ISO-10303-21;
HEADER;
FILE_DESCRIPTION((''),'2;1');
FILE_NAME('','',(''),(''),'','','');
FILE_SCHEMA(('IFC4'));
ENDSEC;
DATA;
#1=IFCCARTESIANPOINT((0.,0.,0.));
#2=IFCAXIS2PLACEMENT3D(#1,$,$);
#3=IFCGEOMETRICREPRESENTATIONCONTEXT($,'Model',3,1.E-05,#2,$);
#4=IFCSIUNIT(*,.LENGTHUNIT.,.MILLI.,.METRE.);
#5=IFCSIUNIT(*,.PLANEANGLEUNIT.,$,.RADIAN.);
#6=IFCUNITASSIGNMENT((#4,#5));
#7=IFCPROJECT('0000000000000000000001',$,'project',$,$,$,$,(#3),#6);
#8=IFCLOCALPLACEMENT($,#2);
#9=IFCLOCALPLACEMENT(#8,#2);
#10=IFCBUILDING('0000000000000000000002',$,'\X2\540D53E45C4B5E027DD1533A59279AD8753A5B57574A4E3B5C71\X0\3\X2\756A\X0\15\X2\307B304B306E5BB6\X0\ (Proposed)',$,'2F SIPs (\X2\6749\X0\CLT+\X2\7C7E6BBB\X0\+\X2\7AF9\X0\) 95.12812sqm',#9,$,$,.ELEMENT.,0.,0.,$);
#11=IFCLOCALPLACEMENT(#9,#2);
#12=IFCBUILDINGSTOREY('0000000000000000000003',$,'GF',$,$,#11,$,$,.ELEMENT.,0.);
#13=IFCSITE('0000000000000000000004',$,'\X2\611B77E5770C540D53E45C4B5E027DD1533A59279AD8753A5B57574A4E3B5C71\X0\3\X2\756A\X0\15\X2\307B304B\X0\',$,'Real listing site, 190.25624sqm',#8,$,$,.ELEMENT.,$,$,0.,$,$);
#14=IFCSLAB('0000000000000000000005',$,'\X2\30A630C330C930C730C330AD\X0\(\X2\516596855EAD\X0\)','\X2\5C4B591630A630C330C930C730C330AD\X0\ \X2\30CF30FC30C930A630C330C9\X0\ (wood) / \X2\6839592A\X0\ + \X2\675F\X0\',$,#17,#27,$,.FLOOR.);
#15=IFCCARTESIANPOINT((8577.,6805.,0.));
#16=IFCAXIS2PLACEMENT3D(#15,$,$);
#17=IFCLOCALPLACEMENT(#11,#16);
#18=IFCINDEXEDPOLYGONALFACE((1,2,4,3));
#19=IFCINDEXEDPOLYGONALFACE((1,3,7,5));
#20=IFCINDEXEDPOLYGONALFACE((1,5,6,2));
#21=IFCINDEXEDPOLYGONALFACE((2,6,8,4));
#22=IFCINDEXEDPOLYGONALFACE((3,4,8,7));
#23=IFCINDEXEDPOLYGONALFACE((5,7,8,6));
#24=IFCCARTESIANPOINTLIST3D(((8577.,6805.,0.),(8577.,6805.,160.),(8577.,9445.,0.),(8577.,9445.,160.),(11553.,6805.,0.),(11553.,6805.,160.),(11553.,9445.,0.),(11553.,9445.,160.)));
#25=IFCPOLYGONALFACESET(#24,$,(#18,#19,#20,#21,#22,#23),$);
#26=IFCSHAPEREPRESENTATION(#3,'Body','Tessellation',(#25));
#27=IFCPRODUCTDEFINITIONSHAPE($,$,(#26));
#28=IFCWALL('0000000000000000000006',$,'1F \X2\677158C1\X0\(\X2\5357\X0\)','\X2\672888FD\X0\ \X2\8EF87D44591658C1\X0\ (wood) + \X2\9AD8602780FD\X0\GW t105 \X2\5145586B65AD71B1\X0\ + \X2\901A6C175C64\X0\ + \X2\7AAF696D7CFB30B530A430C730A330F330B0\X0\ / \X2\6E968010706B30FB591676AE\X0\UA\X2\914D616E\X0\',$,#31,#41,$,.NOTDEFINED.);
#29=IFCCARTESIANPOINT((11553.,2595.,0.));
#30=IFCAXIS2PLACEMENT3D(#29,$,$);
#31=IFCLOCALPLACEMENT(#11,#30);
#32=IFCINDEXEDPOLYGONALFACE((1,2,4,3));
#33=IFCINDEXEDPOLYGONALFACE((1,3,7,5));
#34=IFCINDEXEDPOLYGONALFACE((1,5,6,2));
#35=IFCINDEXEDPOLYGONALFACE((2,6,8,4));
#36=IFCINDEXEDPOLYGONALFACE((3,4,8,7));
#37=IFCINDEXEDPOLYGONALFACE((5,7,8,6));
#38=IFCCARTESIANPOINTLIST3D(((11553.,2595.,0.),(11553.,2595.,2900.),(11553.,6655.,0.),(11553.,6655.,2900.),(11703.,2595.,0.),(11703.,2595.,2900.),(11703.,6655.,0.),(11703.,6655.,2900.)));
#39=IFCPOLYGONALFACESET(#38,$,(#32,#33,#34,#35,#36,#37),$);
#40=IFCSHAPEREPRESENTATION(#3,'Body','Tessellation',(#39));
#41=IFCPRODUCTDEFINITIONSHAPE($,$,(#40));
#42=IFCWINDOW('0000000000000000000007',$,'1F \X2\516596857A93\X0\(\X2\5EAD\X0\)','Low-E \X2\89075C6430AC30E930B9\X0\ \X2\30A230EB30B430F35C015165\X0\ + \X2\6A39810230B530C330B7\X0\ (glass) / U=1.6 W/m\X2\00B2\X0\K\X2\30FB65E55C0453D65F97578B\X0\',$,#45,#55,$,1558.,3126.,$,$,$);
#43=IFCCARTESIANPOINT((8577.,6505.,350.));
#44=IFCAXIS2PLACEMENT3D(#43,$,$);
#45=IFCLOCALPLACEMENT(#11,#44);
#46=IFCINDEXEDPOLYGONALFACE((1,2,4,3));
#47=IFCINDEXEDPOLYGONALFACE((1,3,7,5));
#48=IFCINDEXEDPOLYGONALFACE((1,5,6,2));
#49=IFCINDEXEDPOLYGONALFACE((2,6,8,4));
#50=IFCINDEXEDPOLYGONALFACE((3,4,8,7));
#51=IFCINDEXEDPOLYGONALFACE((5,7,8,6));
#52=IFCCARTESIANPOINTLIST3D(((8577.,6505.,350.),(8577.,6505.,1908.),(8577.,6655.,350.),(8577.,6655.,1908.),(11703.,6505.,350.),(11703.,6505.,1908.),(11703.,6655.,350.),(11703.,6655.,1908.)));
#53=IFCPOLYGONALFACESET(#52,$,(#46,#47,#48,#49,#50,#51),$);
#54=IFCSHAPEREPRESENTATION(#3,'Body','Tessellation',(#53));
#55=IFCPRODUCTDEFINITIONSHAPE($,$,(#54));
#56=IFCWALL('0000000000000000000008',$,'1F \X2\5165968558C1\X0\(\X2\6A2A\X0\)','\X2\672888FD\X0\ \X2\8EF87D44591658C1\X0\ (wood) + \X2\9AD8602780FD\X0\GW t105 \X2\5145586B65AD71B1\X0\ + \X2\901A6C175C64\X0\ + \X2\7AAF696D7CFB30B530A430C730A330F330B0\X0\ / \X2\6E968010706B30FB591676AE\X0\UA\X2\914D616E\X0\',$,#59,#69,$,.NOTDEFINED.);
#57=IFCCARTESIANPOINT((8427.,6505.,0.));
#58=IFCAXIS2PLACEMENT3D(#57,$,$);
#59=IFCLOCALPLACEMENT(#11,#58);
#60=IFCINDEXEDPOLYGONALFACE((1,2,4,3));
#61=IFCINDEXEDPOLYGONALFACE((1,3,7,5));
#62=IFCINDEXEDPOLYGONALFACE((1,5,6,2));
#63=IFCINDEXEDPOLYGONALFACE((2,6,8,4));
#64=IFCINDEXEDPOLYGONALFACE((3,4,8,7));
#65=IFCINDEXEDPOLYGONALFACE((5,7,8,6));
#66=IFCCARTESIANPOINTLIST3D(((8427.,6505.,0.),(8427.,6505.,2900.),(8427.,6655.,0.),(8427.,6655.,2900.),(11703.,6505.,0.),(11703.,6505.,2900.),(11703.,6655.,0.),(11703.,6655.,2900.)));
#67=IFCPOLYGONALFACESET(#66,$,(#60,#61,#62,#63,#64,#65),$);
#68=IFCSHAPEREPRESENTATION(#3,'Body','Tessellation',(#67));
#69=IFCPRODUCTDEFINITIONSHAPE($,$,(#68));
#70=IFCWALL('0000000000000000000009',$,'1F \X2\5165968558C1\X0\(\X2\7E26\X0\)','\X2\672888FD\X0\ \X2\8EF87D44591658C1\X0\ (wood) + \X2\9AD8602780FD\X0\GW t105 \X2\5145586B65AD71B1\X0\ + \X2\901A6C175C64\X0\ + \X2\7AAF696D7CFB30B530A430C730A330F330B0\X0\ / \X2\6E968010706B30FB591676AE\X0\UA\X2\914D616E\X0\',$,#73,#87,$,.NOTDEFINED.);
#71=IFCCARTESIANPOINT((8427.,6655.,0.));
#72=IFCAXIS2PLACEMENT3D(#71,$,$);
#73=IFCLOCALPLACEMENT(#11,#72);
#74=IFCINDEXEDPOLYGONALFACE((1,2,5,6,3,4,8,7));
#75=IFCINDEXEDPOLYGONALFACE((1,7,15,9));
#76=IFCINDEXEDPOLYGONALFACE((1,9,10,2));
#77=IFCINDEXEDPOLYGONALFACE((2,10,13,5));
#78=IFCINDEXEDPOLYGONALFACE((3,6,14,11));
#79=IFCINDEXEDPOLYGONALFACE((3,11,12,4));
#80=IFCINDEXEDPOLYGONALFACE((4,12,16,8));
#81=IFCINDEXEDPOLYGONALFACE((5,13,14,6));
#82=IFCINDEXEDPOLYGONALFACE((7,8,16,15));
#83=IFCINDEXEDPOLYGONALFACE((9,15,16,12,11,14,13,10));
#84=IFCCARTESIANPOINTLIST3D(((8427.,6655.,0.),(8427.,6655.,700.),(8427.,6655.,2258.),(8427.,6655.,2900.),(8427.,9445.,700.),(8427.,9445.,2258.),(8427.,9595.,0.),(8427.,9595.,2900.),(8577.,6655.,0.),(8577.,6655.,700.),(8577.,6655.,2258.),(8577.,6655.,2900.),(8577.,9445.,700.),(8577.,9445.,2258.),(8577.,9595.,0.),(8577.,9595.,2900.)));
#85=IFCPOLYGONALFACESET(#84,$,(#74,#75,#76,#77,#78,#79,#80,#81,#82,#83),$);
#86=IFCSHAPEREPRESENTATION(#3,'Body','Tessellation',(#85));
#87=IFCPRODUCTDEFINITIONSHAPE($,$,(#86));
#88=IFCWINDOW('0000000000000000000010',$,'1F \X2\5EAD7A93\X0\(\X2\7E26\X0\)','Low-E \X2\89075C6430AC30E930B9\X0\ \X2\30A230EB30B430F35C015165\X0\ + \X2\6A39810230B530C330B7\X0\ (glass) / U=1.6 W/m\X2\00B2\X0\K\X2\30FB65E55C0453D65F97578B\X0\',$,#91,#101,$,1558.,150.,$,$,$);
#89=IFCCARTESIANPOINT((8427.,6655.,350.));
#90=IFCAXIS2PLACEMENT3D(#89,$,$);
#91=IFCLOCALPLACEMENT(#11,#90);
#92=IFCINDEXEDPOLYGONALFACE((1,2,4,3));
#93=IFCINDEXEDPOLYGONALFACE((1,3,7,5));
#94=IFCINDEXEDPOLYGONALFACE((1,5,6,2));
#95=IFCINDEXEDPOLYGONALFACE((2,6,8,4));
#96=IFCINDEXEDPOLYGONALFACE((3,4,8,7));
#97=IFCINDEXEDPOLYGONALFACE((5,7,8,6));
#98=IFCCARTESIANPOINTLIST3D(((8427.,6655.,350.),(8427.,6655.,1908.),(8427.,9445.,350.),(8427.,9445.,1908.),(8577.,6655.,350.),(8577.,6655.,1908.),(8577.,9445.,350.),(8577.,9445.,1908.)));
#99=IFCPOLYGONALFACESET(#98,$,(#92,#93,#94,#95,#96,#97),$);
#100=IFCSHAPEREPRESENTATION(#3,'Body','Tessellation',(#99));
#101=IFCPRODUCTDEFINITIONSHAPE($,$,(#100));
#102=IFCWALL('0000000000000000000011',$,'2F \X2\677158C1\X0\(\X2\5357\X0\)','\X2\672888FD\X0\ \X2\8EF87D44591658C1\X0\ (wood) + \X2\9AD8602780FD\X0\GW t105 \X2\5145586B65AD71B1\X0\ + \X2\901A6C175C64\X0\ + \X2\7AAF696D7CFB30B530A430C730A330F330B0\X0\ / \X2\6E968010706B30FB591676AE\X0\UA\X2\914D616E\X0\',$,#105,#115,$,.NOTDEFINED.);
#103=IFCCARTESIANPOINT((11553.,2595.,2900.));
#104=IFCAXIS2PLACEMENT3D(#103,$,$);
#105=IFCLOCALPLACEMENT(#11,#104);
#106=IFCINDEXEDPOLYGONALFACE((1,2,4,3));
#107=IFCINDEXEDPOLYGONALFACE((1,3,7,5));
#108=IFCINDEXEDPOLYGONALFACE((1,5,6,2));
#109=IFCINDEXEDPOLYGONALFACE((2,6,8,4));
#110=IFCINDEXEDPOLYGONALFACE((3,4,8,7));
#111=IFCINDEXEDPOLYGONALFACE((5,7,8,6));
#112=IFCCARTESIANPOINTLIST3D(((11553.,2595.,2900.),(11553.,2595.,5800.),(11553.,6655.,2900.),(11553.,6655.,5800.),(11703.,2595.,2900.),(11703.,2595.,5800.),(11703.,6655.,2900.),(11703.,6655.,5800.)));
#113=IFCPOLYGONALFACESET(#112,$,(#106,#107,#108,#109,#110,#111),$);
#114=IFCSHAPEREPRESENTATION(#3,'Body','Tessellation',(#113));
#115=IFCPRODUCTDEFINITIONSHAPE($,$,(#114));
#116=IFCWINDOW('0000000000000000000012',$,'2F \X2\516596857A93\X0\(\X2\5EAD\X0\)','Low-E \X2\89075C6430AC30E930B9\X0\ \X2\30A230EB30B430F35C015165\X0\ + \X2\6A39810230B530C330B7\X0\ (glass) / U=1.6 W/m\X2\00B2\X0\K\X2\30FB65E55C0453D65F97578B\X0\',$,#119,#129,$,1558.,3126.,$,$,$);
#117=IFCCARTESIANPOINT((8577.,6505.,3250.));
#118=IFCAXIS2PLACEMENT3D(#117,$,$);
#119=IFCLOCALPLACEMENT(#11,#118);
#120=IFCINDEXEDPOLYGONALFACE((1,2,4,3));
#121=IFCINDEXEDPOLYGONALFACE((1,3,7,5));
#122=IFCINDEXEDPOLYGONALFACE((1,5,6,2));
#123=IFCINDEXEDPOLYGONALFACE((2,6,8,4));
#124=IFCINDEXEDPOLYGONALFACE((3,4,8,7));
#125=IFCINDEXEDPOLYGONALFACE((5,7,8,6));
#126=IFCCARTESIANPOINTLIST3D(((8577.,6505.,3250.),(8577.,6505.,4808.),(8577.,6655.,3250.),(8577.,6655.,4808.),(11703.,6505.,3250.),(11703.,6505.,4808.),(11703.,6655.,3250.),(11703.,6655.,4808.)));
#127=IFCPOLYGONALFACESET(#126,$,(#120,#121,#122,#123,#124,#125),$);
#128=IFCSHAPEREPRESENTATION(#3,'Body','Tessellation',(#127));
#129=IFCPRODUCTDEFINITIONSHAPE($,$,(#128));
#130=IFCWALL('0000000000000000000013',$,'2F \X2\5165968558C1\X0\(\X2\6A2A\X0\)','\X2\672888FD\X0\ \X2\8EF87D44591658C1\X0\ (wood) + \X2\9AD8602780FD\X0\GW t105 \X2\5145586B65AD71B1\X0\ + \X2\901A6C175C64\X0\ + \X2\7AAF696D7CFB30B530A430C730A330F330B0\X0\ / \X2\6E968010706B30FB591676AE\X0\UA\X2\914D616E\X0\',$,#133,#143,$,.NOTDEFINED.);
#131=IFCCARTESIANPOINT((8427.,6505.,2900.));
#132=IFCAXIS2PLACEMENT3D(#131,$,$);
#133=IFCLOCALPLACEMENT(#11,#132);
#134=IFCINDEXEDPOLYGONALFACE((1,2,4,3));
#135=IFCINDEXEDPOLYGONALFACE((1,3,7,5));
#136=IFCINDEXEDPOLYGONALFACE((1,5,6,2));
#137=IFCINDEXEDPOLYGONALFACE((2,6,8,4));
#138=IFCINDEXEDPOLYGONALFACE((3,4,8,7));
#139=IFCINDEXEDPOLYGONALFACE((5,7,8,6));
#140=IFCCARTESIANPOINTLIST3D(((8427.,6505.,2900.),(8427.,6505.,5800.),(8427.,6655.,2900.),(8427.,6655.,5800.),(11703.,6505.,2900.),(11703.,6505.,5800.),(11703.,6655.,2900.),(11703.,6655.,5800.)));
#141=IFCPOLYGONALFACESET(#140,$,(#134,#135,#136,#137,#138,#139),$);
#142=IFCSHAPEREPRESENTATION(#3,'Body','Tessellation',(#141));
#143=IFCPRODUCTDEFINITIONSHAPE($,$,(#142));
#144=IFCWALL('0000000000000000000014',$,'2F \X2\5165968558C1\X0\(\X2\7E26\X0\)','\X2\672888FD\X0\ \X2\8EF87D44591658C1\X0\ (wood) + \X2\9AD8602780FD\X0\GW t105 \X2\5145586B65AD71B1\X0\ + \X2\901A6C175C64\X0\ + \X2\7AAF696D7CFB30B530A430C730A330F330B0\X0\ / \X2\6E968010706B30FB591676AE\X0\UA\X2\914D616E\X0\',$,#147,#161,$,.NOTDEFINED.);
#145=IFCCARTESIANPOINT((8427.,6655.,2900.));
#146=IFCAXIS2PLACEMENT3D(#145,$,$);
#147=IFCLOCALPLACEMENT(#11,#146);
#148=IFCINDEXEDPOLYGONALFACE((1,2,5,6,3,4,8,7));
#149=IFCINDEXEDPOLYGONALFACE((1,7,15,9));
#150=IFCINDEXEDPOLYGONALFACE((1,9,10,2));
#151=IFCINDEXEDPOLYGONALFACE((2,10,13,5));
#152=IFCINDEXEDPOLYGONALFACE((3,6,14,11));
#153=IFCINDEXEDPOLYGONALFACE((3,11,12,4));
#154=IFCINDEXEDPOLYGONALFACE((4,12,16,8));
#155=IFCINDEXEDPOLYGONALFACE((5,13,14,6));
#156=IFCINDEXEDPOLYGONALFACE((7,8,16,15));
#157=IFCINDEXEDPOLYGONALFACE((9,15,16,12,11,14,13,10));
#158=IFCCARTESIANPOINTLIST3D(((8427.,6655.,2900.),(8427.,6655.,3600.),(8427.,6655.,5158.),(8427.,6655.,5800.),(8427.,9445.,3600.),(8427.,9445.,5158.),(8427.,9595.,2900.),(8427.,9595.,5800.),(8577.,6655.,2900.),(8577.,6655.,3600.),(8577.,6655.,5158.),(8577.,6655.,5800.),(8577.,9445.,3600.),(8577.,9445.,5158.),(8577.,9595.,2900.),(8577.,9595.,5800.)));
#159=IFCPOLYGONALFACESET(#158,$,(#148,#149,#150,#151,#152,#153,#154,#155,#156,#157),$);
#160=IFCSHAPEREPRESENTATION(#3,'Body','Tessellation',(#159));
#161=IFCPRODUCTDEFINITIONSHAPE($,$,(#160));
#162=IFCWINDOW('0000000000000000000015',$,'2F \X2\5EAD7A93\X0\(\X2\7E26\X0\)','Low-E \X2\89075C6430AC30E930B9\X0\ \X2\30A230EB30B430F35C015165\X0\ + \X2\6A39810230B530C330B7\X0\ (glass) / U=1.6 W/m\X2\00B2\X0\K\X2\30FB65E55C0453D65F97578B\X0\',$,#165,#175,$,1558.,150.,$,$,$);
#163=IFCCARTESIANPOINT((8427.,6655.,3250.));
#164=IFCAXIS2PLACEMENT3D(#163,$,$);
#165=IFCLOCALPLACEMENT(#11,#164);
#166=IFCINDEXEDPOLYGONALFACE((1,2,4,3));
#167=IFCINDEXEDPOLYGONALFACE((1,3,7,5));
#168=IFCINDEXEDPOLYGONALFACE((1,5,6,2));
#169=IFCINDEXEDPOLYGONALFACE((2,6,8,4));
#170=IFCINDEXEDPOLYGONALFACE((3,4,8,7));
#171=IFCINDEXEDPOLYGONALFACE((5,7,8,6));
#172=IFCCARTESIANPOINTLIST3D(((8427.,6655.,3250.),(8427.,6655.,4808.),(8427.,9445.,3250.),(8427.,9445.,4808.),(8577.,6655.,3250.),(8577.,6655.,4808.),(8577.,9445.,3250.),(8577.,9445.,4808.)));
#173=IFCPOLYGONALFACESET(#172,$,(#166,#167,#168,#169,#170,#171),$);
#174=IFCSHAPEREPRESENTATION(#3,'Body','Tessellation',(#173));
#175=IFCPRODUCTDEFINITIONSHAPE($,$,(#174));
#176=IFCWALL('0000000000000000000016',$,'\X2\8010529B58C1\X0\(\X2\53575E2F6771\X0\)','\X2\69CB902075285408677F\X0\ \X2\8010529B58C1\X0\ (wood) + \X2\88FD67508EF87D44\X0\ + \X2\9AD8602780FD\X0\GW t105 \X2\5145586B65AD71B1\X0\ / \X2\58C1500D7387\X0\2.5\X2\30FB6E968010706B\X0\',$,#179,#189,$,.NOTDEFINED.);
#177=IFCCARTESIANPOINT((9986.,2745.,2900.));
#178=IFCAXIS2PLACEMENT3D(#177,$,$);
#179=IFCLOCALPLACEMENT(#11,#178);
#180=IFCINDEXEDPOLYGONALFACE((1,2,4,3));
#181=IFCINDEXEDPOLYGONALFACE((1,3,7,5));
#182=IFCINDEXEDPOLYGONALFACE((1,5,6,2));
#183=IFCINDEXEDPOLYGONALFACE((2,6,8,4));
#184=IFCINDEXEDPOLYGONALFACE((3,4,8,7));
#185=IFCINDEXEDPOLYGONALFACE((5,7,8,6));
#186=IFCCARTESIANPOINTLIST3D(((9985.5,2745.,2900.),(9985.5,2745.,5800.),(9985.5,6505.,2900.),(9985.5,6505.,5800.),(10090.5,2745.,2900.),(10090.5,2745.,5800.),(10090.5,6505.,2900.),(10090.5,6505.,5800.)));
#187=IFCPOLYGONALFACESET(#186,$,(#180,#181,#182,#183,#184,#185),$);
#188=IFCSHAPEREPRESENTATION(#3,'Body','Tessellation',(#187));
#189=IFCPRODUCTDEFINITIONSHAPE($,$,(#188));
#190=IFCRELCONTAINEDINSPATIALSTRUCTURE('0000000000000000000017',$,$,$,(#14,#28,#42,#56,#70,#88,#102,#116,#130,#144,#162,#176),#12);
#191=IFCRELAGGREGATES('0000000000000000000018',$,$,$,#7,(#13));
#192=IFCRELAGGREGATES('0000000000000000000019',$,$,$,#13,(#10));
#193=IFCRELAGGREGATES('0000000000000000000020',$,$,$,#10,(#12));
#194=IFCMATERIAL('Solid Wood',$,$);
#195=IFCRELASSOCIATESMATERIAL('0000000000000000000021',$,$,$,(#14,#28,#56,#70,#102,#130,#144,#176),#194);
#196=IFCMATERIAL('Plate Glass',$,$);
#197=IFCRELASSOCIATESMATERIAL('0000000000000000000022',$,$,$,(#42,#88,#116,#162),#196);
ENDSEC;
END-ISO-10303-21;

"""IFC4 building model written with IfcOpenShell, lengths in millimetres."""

from ifc_helpers import new_model, si_unit, frame, frame_2d, origin, place, context, project, spatial, rectangle, extrude, material, element, fill, save


model = new_model("IFC4")

# Units and contexts
model_context = context("Model", 3, precision=1e-05, world=origin())
ifc_project = project(units=[si_unit("LENGTHUNIT", "METRE", prefix="MILLI"), si_unit("PLANEANGLEUNIT", "RADIAN")], contexts=[model_context])

# Site, building, storey
site_placement = place(None, origin())
site = spatial("IfcSite", under=ifc_project, at=site_placement, Name="愛知県名古屋市緑区大高町字坊主山3番15ほか", ObjectType="Real listing site, 190.25624sqm", CompositionType="ELEMENT", RefElevation=0.0)
building_placement = place(site_placement, origin())
building = spatial("IfcBuilding", under=site, at=building_placement, Name="名古屋市緑区大高町字坊主山3番15ほかの家 (Proposed)", ObjectType="2F SIPs (杉CLT+籾殻+竹) 95.12812sqm", CompositionType="ELEMENT", ElevationOfRefHeight=0.0, ElevationOfTerrain=0.0)
storey_placement = place(building_placement, origin())
storey = spatial("IfcBuildingStorey", under=building, at=storey_placement, Name="GF", CompositionType="ELEMENT", Elevation=0.0)

# Slab
ifc_material_1 = material(Name="Solid Wood")
slab_placement = place(storey_placement, frame((8577.0, 6805.0, 0.0)))
element("IfcSlab", 1, at=slab_placement, inside=storey, material=ifc_material_1, Name="ウッドデッキ(入隅庭)", Description="屋外ウッドデッキ ハードウッド (wood) / 根太 + 束", PredefinedType="FLOOR", context=model_context, shape_type="SweptSolid", body=[
    extrude(rectangle(XDim=2976.0, YDim=2640.0, at=frame_2d((1488.0, 1320.0))), frame((8577.0, 6805.0, 0.0)), (0.0, 0.0, 1.0), 160.0),
])

# Wall, opening, window
wall_1_placement = place(storey_placement, frame((11553.0, 2595.0, 0.0)))
wall_1 = element("IfcWall", 2, at=wall_1_placement, inside=storey, material=ifc_material_1, Name="1F 東壁(南)", Description="木製 軸組外壁 (wood) + 高性能GW t105 充填断熱 + 通気層 + 窯業系サイディング / 準耐火・外皮UA配慮", PredefinedType="NOTDEFINED", context=model_context, shape_type="SweptSolid", body=[
    extrude(rectangle(XDim=150.0, YDim=4060.0, at=frame_2d((75.0, 2030.0))), frame((11553.0, 2595.0, 0.0)), (0.0, 0.0, 1.0), 2900.0),
])
opening_1_placement = place(storey_placement, frame((8577.0, 6505.0, 350.0)))
opening_1 = element("IfcOpeningElement", 3, at=opening_1_placement, cuts=wall_1, PredefinedType="NOTDEFINED", context=model_context, shape_type="SweptSolid", body=[
    extrude(rectangle(XDim=3126.0, YDim=150.0, at=frame_2d((1563.0, 75.0))), frame((8577.0, 6505.0, 350.0)), (0.0, 0.0, 1.0), 1558.0),
])
ifc_material_2 = material(Name="Plate Glass")
window_1_placement = place(storey_placement, frame((8577.0, 6505.0, 350.0)))
window_1 = element("IfcWindow", 4, at=window_1_placement, inside=storey, material=ifc_material_2, Name="1F 入隅窓(庭)", Description="Low-E 複層ガラス アルゴン封入 + 樹脂サッシ (glass) / U=1.6 W/m²K・日射取得型", OverallHeight=1558.0, OverallWidth=3126.0, context=model_context, shape_type="SweptSolid", body=[
    extrude(rectangle(XDim=3126.0, YDim=150.0, at=frame_2d((1563.0, 75.0))), frame((8577.0, 6505.0, 350.0)), (0.0, 0.0, 1.0), 1558.0),
])
fill(opening_1, window_1)

# Wall
wall_2_placement = place(storey_placement, frame((8427.0, 6505.0, 0.0)))
element("IfcWall", 5, at=wall_2_placement, inside=storey, material=ifc_material_1, Name="1F 入隅壁(横)", Description="木製 軸組外壁 (wood) + 高性能GW t105 充填断熱 + 通気層 + 窯業系サイディング / 準耐火・外皮UA配慮", PredefinedType="NOTDEFINED", context=model_context, shape_type="SweptSolid", body=[
    extrude(rectangle(XDim=3276.0, YDim=150.0, at=frame_2d((1638.0, 75.0))), frame((8427.0, 6505.0, 0.0)), (0.0, 0.0, 1.0), 2900.0),
])

# Wall, opening, window
wall_3_placement = place(storey_placement, frame((8427.0, 6655.0, 0.0)))
wall_3 = element("IfcWall", 6, at=wall_3_placement, inside=storey, material=ifc_material_1, Name="1F 入隅壁(縦)", Description="木製 軸組外壁 (wood) + 高性能GW t105 充填断熱 + 通気層 + 窯業系サイディング / 準耐火・外皮UA配慮", PredefinedType="NOTDEFINED", context=model_context, shape_type="SweptSolid", body=[
    extrude(rectangle(XDim=150.0, YDim=2940.0, at=frame_2d((75.0, 1470.0))), frame((8427.0, 6655.0, 0.0)), (0.0, 0.0, 1.0), 2900.0),
])
opening_2_placement = place(storey_placement, frame((8427.0, 6655.0, 350.0)))
opening_2 = element("IfcOpeningElement", 7, at=opening_2_placement, cuts=wall_3, PredefinedType="NOTDEFINED", context=model_context, shape_type="SweptSolid", body=[
    extrude(rectangle(XDim=150.0, YDim=2790.0, at=frame_2d((75.0, 1395.0))), frame((8427.0, 6655.0, 350.0)), (0.0, 0.0, 1.0), 1558.0),
])
window_2_placement = place(storey_placement, frame((8427.0, 6655.0, 350.0)))
window_2 = element("IfcWindow", 8, at=window_2_placement, inside=storey, material=ifc_material_2, Name="1F 庭窓(縦)", Description="Low-E 複層ガラス アルゴン封入 + 樹脂サッシ (glass) / U=1.6 W/m²K・日射取得型", OverallHeight=1558.0, OverallWidth=150.0, context=model_context, shape_type="SweptSolid", body=[
    extrude(rectangle(XDim=150.0, YDim=2790.0, at=frame_2d((75.0, 1395.0))), frame((8427.0, 6655.0, 350.0)), (0.0, 0.0, 1.0), 1558.0),
])
fill(opening_2, window_2)

# Wall, opening, window
wall_4_placement = place(storey_placement, frame((11553.0, 2595.0, 2900.0)))
wall_4 = element("IfcWall", 9, at=wall_4_placement, inside=storey, material=ifc_material_1, Name="2F 東壁(南)", Description="木製 軸組外壁 (wood) + 高性能GW t105 充填断熱 + 通気層 + 窯業系サイディング / 準耐火・外皮UA配慮", PredefinedType="NOTDEFINED", context=model_context, shape_type="SweptSolid", body=[
    extrude(rectangle(XDim=150.0, YDim=4060.0, at=frame_2d((75.0, 2030.0))), frame((11553.0, 2595.0, 2900.0)), (0.0, 0.0, 1.0), 2900.0),
])
opening_3_placement = place(storey_placement, frame((8577.0, 6505.0, 3250.0)))
opening_3 = element("IfcOpeningElement", 10, at=opening_3_placement, cuts=wall_4, PredefinedType="NOTDEFINED", context=model_context, shape_type="SweptSolid", body=[
    extrude(rectangle(XDim=3126.0, YDim=150.0, at=frame_2d((1563.0, 75.0))), frame((8577.0, 6505.0, 3250.0)), (0.0, 0.0, 1.0), 1558.0),
])
window_3_placement = place(storey_placement, frame((8577.0, 6505.0, 3250.0)))
window_3 = element("IfcWindow", 11, at=window_3_placement, inside=storey, material=ifc_material_2, Name="2F 入隅窓(庭)", Description="Low-E 複層ガラス アルゴン封入 + 樹脂サッシ (glass) / U=1.6 W/m²K・日射取得型", OverallHeight=1558.0, OverallWidth=3126.0, context=model_context, shape_type="SweptSolid", body=[
    extrude(rectangle(XDim=3126.0, YDim=150.0, at=frame_2d((1563.0, 75.0))), frame((8577.0, 6505.0, 3250.0)), (0.0, 0.0, 1.0), 1558.0),
])
fill(opening_3, window_3)

# Wall
wall_5_placement = place(storey_placement, frame((8427.0, 6505.0, 2900.0)))
element("IfcWall", 12, at=wall_5_placement, inside=storey, material=ifc_material_1, Name="2F 入隅壁(横)", Description="木製 軸組外壁 (wood) + 高性能GW t105 充填断熱 + 通気層 + 窯業系サイディング / 準耐火・外皮UA配慮", PredefinedType="NOTDEFINED", context=model_context, shape_type="SweptSolid", body=[
    extrude(rectangle(XDim=3276.0, YDim=150.0, at=frame_2d((1638.0, 75.0))), frame((8427.0, 6505.0, 2900.0)), (0.0, 0.0, 1.0), 2900.0),
])

# Wall, opening, window
wall_6_placement = place(storey_placement, frame((8427.0, 6655.0, 2900.0)))
wall_6 = element("IfcWall", 13, at=wall_6_placement, inside=storey, material=ifc_material_1, Name="2F 入隅壁(縦)", Description="木製 軸組外壁 (wood) + 高性能GW t105 充填断熱 + 通気層 + 窯業系サイディング / 準耐火・外皮UA配慮", PredefinedType="NOTDEFINED", context=model_context, shape_type="SweptSolid", body=[
    extrude(rectangle(XDim=150.0, YDim=2940.0, at=frame_2d((75.0, 1470.0))), frame((8427.0, 6655.0, 2900.0)), (0.0, 0.0, 1.0), 2900.0),
])
opening_4_placement = place(storey_placement, frame((8427.0, 6655.0, 3250.0)))
opening_4 = element("IfcOpeningElement", 14, at=opening_4_placement, cuts=wall_6, PredefinedType="NOTDEFINED", context=model_context, shape_type="SweptSolid", body=[
    extrude(rectangle(XDim=150.0, YDim=2790.0, at=frame_2d((75.0, 1395.0))), frame((8427.0, 6655.0, 3250.0)), (0.0, 0.0, 1.0), 1558.0),
])
window_4_placement = place(storey_placement, frame((8427.0, 6655.0, 3250.0)))
window_4 = element("IfcWindow", 15, at=window_4_placement, inside=storey, material=ifc_material_2, Name="2F 庭窓(縦)", Description="Low-E 複層ガラス アルゴン封入 + 樹脂サッシ (glass) / U=1.6 W/m²K・日射取得型", OverallHeight=1558.0, OverallWidth=150.0, context=model_context, shape_type="SweptSolid", body=[
    extrude(rectangle(XDim=150.0, YDim=2790.0, at=frame_2d((75.0, 1395.0))), frame((8427.0, 6655.0, 3250.0)), (0.0, 0.0, 1.0), 1558.0),
])
fill(opening_4, window_4)

# Wall
wall_7_placement = place(storey_placement, frame((9986.0, 2745.0, 2900.0)))
element("IfcWall", 16, at=wall_7_placement, inside=storey, material=ifc_material_1, Name="耐力壁(南帯東)", Description="構造用合板 耐力壁 (wood) + 製材軸組 + 高性能GW t105 充填断熱 / 壁倍率2.5・準耐火", PredefinedType="NOTDEFINED", context=model_context, shape_type="SweptSolid", body=[
    extrude(rectangle(XDim=105.0, YDim=3760.0, at=frame_2d((52.0, 1880.0))), frame((9986.0, 2745.0, 2900.0)), (0.0, 0.0, 1.0), 2900.0),
])

save(model, "model.ifc")
